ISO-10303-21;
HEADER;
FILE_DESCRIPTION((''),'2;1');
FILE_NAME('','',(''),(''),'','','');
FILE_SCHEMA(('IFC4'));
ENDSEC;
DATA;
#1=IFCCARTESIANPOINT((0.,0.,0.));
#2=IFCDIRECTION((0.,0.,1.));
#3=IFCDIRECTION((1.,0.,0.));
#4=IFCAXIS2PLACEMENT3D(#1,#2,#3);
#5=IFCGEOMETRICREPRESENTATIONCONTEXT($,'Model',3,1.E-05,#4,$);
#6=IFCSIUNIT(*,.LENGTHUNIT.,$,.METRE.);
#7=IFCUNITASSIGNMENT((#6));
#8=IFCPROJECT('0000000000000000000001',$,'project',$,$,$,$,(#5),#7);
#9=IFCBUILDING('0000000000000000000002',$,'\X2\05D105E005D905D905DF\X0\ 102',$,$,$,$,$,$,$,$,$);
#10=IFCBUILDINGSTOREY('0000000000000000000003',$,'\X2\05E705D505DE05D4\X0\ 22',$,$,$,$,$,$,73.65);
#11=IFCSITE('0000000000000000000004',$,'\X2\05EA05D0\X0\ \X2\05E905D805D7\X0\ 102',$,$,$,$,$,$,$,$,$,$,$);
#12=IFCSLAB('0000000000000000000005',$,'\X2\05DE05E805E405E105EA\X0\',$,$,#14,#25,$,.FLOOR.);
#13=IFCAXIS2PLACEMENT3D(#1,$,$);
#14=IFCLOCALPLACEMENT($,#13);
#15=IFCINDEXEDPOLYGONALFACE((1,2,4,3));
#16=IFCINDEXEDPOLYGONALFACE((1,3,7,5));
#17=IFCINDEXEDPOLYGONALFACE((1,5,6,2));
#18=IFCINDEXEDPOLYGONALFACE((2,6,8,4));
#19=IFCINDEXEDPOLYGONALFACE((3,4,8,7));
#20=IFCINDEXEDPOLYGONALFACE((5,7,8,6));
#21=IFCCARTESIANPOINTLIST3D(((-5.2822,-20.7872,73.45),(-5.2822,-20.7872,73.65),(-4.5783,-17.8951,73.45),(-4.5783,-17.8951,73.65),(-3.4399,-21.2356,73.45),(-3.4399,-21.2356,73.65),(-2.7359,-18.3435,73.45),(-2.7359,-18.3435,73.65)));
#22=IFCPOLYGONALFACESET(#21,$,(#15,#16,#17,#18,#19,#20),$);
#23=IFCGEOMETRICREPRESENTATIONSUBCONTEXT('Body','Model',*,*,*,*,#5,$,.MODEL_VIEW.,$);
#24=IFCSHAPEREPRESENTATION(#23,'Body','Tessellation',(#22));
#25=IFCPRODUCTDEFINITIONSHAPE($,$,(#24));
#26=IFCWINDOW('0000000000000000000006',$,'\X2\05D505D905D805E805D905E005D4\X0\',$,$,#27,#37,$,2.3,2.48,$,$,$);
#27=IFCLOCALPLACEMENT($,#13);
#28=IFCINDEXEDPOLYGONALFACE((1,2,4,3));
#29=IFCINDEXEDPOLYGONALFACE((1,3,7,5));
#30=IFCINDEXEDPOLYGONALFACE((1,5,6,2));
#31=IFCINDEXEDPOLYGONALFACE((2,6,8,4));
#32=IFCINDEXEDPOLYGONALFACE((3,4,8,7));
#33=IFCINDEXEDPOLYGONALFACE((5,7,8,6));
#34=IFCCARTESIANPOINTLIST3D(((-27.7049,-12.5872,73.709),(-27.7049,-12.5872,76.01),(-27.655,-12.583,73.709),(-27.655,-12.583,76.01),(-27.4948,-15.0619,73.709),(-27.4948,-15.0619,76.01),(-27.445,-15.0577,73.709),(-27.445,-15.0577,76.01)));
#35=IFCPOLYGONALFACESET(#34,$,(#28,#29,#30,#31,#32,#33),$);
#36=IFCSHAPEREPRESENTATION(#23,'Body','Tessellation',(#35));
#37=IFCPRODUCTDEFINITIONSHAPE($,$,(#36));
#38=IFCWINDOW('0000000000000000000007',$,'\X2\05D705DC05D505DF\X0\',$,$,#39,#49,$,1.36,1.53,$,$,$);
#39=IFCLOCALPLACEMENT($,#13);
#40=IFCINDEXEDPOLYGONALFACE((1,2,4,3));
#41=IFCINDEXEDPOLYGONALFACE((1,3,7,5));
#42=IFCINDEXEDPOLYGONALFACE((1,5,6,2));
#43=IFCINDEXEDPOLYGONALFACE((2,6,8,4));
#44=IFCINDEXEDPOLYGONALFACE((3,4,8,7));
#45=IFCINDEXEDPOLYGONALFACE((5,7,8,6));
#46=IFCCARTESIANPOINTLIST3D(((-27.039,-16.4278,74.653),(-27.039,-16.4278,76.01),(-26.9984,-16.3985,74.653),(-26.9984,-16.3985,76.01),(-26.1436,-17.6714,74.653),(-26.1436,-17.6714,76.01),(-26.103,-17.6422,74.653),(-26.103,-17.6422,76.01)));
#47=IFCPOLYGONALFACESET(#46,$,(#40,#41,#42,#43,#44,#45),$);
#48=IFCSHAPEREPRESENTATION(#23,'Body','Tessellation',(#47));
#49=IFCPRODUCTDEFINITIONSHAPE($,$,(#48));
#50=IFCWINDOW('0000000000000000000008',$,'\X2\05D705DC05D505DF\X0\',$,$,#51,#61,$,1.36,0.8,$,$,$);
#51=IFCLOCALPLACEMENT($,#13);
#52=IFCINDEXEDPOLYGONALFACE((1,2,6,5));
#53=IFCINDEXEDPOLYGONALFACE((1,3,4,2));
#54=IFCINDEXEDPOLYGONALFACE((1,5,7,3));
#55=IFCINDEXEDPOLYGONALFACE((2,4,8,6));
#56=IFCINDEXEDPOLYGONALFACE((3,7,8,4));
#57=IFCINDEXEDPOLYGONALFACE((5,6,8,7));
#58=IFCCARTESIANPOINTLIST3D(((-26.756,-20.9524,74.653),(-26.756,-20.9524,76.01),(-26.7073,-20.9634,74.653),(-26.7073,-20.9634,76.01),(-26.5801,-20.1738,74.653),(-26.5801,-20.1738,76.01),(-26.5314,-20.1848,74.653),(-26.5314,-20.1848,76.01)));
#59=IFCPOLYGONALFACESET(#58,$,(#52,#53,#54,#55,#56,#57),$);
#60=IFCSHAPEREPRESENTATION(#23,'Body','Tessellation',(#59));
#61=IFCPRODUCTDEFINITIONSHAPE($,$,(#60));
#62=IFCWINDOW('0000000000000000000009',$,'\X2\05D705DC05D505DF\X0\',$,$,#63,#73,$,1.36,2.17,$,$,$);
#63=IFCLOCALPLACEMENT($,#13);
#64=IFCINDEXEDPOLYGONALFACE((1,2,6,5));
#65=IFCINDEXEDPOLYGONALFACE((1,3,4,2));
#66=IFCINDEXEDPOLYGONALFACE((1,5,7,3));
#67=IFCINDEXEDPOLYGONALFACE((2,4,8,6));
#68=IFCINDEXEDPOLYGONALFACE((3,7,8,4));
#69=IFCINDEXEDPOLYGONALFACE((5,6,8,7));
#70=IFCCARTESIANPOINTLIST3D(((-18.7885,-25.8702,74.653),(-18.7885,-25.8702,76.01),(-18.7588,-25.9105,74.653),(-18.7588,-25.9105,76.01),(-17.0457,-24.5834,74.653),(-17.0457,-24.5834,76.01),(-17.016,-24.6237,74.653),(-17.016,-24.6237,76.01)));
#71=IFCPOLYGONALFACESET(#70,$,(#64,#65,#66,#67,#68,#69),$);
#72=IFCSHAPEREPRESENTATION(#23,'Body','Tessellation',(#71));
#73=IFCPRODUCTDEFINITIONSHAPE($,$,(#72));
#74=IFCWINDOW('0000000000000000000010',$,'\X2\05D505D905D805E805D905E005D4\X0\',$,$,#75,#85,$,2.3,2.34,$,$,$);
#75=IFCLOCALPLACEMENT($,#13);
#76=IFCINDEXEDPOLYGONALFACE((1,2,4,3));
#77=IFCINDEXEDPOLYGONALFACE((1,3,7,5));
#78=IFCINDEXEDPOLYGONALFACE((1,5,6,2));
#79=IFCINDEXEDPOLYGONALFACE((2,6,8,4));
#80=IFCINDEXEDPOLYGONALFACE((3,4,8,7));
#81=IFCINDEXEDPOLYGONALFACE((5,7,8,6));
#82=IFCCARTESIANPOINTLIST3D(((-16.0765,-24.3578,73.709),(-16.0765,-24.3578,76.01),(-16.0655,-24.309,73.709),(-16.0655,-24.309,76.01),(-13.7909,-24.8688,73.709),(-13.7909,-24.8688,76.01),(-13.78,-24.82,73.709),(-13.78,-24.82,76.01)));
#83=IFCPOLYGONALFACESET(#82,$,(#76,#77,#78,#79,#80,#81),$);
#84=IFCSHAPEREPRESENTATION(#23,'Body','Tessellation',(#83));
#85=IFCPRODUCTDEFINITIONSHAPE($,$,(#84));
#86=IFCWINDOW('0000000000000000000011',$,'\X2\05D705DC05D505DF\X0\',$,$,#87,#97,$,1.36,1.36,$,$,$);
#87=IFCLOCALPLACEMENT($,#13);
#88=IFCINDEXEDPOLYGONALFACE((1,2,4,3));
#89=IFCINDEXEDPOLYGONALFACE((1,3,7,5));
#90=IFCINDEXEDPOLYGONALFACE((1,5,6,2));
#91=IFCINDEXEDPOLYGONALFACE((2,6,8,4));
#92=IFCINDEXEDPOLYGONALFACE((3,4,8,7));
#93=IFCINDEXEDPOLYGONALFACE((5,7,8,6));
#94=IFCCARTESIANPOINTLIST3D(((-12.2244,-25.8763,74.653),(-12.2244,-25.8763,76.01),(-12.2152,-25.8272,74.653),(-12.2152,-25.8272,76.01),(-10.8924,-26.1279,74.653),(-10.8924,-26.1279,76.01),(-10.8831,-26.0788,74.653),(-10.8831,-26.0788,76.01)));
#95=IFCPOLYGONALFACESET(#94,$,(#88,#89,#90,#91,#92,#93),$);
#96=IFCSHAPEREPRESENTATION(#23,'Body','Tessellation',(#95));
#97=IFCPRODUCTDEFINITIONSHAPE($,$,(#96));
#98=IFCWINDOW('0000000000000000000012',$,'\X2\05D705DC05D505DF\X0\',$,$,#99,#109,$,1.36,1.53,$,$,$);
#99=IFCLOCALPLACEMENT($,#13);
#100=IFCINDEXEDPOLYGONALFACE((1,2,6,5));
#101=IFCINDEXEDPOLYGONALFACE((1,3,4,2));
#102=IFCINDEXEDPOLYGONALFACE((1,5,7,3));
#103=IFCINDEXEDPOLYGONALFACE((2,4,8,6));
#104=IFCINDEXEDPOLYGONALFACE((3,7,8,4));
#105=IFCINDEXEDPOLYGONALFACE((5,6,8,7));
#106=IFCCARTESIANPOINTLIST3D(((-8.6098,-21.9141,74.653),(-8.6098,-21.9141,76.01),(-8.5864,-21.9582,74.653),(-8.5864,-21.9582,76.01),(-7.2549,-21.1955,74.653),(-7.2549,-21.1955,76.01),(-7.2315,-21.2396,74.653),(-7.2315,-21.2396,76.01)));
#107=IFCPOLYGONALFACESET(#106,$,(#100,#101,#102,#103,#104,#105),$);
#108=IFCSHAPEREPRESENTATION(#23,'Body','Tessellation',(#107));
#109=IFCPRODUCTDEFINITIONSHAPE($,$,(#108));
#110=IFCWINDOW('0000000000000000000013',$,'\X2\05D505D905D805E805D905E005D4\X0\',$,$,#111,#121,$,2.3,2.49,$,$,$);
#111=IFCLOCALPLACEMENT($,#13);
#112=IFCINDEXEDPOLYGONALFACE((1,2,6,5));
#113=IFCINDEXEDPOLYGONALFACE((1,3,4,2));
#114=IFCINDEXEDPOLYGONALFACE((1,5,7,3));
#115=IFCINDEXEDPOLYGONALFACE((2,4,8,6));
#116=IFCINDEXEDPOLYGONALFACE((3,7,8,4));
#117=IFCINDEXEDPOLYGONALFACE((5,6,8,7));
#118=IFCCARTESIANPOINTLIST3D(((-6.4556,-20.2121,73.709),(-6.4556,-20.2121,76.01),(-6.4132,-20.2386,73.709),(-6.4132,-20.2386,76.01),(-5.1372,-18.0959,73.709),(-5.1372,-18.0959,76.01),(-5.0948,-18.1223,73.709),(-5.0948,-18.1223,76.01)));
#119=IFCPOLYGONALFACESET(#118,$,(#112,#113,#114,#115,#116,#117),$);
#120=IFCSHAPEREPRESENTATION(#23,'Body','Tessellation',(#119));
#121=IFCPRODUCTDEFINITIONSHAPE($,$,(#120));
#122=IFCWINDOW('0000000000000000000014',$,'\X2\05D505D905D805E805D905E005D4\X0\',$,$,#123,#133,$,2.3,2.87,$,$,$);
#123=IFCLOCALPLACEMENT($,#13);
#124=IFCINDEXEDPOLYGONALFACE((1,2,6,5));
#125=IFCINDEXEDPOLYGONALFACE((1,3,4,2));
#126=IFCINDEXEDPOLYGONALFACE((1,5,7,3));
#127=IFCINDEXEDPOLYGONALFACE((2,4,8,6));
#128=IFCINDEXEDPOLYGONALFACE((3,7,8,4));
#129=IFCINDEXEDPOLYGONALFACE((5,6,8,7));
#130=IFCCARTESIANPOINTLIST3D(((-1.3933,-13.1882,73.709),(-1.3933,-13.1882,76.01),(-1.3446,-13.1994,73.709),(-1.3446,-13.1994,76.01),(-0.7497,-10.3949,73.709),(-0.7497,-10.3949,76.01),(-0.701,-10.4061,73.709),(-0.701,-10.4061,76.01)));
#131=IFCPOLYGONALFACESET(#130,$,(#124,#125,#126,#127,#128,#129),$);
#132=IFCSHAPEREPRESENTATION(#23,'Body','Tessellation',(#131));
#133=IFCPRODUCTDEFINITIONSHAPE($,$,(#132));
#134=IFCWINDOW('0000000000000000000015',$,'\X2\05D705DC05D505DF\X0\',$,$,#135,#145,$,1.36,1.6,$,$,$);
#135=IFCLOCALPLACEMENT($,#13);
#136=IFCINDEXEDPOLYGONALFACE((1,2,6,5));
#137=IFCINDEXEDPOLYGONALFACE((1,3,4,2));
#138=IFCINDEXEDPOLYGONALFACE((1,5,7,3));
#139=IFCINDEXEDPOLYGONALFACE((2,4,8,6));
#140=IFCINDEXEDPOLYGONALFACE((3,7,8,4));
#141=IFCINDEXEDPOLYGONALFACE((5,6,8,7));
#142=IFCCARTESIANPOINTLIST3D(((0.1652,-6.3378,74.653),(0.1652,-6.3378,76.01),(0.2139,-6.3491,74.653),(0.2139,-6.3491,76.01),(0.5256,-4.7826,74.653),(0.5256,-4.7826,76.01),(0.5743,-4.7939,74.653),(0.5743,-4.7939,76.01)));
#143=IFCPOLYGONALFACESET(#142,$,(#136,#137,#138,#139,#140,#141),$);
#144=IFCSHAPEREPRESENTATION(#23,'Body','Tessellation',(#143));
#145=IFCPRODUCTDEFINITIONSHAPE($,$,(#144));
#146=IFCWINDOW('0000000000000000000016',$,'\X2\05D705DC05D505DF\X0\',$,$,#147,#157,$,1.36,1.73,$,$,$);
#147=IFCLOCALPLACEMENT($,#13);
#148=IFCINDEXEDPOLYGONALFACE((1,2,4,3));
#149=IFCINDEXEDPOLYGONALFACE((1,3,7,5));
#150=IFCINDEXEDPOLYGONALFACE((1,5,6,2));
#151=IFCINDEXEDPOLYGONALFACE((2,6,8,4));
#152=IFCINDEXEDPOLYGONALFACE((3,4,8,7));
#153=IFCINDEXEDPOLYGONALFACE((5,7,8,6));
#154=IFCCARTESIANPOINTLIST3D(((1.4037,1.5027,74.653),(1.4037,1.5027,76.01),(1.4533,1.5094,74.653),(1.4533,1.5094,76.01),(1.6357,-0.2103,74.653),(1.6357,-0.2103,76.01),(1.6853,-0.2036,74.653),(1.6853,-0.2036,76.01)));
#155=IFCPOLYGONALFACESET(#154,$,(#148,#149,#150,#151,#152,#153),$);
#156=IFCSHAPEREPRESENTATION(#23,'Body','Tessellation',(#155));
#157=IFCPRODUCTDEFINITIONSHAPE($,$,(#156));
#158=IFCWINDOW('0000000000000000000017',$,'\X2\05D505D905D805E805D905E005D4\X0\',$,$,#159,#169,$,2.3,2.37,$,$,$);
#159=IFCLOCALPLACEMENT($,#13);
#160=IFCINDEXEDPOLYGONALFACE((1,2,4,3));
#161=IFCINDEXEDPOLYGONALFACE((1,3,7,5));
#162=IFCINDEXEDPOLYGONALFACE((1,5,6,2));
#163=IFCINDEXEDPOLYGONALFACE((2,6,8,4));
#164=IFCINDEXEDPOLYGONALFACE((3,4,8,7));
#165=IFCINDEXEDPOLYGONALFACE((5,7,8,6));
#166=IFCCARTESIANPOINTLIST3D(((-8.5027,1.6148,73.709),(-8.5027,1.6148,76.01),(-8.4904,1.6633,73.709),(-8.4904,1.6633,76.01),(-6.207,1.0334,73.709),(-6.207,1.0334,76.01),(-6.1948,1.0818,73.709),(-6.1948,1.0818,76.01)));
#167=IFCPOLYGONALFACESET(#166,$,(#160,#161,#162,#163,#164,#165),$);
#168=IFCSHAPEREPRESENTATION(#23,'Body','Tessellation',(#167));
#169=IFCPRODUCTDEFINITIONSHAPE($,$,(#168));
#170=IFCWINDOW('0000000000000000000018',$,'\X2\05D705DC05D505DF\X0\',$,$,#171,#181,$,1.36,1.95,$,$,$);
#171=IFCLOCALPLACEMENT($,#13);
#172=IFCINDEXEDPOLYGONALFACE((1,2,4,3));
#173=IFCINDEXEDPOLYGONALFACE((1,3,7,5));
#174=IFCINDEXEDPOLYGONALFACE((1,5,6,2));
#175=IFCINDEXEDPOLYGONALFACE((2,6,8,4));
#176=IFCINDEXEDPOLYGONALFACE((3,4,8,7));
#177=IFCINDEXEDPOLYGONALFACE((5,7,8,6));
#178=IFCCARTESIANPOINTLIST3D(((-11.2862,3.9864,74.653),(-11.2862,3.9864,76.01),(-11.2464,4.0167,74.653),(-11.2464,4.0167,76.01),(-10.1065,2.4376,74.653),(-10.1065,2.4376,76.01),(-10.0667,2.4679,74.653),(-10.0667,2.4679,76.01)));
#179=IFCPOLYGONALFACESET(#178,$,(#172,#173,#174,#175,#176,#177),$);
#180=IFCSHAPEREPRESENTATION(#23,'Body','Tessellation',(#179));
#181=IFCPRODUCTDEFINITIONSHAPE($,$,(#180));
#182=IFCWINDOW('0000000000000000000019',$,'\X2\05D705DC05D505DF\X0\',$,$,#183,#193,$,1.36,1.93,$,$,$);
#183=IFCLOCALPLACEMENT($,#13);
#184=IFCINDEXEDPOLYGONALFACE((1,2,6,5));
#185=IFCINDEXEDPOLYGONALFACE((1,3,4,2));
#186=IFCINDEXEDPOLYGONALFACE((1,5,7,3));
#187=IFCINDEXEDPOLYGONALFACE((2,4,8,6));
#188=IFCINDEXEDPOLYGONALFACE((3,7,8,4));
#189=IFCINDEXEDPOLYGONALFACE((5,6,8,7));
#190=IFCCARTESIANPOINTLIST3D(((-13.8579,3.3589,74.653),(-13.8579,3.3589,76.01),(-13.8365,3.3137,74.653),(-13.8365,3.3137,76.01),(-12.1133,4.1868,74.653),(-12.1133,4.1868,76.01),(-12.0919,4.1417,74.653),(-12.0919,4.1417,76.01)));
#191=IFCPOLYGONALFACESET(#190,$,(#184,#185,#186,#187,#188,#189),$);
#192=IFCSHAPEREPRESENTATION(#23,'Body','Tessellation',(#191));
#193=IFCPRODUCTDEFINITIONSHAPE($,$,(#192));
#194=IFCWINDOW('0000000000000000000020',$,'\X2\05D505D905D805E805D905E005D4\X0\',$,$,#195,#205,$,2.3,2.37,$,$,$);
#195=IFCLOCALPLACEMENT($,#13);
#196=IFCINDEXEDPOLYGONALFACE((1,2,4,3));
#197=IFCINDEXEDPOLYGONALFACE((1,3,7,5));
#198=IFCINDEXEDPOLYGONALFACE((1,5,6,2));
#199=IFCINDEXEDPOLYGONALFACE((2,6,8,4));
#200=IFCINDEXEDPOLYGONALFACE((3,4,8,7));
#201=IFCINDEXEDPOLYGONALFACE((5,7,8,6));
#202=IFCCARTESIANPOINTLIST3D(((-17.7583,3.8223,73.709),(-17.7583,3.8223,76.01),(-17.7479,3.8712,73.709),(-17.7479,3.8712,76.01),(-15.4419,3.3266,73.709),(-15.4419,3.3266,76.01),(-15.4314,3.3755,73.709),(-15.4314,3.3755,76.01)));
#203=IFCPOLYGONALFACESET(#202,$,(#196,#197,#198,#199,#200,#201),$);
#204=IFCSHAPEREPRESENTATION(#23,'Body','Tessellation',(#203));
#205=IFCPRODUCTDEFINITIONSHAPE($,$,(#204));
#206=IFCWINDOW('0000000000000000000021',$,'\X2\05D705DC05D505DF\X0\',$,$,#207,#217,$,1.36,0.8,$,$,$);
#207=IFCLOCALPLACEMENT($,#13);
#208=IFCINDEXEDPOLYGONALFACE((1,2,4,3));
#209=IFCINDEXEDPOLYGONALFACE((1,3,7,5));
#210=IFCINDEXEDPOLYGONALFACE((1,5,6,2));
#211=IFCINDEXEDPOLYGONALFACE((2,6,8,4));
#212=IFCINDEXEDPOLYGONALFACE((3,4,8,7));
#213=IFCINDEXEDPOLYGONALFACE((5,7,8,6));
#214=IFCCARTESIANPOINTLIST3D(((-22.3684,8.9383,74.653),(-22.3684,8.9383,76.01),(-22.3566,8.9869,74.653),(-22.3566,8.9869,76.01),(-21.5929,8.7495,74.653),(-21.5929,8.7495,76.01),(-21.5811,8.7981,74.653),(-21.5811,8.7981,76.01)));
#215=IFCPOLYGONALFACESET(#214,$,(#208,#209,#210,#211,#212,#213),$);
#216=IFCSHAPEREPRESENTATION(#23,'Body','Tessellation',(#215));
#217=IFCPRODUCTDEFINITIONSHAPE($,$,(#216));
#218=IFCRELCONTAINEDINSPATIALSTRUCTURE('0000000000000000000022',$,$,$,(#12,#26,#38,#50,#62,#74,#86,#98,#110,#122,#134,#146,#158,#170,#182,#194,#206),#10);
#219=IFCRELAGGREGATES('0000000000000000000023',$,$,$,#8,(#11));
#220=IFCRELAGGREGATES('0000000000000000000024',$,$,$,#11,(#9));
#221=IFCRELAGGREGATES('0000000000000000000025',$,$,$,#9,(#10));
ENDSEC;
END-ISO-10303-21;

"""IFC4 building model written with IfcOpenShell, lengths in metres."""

from ifc_helpers import new_model, si_unit, frame, origin_with_axes, context, subcontext, project, spatial, polyline, outline, extrude, element, save


model = new_model("IFC4")

# Units and contexts
model_context = context("Model", 3, precision=1e-05, world=origin_with_axes())
body_context = subcontext(model_context, "Body", "Model", "MODEL_VIEW")
ifc_project = project(units=[si_unit("LENGTHUNIT", "METRE")], contexts=[model_context])

# Site, building, storey
site = spatial("IfcSite", under=ifc_project, Name="תא שטח 102")
building = spatial("IfcBuilding", under=site, Name="בניין 102")
storey = spatial("IfcBuildingStorey", under=building, Name="קומה 22", Elevation=73.65)

# Slab
element("IfcSlab", 1, inside=storey, Name="מרפסת", PredefinedType="FLOOR", context=body_context, shape_type="SweptSolid", body=[
    extrude(outline(polyline([(-4.5783, -17.8951), (-2.7359, -18.3435), (-3.4399, -21.2356), (-5.2822, -20.7872), (-4.5783, -17.8951)])), frame((0.0, 0.0, 73.45)), (0.0, 0.0, 1.0), 0.2),
])

# Windows
element("IfcWindow", 2, inside=storey, Name="ויטרינה", OverallHeight=2.3, OverallWidth=2.48, context=body_context, shape_type="SweptSolid", body=[
    extrude(outline(polyline([(-27.7049, -12.5872), (-27.4948, -15.0619), (-27.445, -15.0577), (-27.655, -12.583), (-27.7049, -12.5872)])), frame((0.0, 0.0, 73.709)), (0.0, 0.0, 1.0), 2.301),
])
element("IfcWindow", 3, inside=storey, Name="חלון", OverallHeight=1.36, OverallWidth=1.53, context=body_context, shape_type="SweptSolid", body=[
    extrude(outline(polyline([(-27.039, -16.4278), (-26.1436, -17.6714), (-26.103, -17.6422), (-26.9984, -16.3985), (-27.039, -16.4278)])), frame((0.0, 0.0, 74.653)), (0.0, 0.0, 1.0), 1.357),
])
element("IfcWindow", 4, inside=storey, Name="חלון", OverallHeight=1.36, OverallWidth=0.8, context=body_context, shape_type="SweptSolid", body=[
    extrude(outline(polyline([(-26.5801, -20.1738), (-26.756, -20.9524), (-26.7073, -20.9634), (-26.5314, -20.1848), (-26.5801, -20.1738)])), frame((0.0, 0.0, 74.653)), (0.0, 0.0, 1.0), 1.357),
])
element("IfcWindow", 5, inside=storey, Name="חלון", OverallHeight=1.36, OverallWidth=2.17, context=body_context, shape_type="SweptSolid", body=[
    extrude(outline(polyline([(-18.7588, -25.9105), (-17.016, -24.6237), (-17.0457, -24.5834), (-18.7885, -25.8702), (-18.7588, -25.9105)])), frame((0.0, 0.0, 74.653)), (0.0, 0.0, 1.0), 1.357),
])
element("IfcWindow", 6, inside=storey, Name="ויטרינה", OverallHeight=2.3, OverallWidth=2.34, context=body_context, shape_type="SweptSolid", body=[
    extrude(outline(polyline([(-16.0765, -24.3578), (-13.7909, -24.8688), (-13.78, -24.82), (-16.0655, -24.309), (-16.0765, -24.3578)])), frame((0.0, 0.0, 73.709)), (0.0, 0.0, 1.0), 2.301),
])
element("IfcWindow", 7, inside=storey, Name="חלון", OverallHeight=1.36, OverallWidth=1.36, context=body_context, shape_type="SweptSolid", body=[
    extrude(outline(polyline([(-12.2244, -25.8763), (-10.8924, -26.1279), (-10.8831, -26.0788), (-12.2152, -25.8272), (-12.2244, -25.8763)])), frame((0.0, 0.0, 74.653)), (0.0, 0.0, 1.0), 1.357),
])
element("IfcWindow", 8, inside=storey, Name="חלון", OverallHeight=1.36, OverallWidth=1.53, context=body_context, shape_type="SweptSolid", body=[
    extrude(outline(polyline([(-8.5864, -21.9582), (-7.2315, -21.2396), (-7.2549, -21.1955), (-8.6098, -21.9141), (-8.5864, -21.9582)])), frame((0.0, 0.0, 74.653)), (0.0, 0.0, 1.0), 1.357),
])
element("IfcWindow", 9, inside=storey, Name="ויטרינה", OverallHeight=2.3, OverallWidth=2.49, context=body_context, shape_type="SweptSolid", body=[
    extrude(outline(polyline([(-6.4132, -20.2386), (-5.0948, -18.1223), (-5.1372, -18.0959), (-6.4556, -20.2121), (-6.4132, -20.2386)])), frame((0.0, 0.0, 73.709)), (0.0, 0.0, 1.0), 2.301),
])
element("IfcWindow", 10, inside=storey, Name="ויטרינה", OverallHeight=2.3, OverallWidth=2.87, context=body_context, shape_type="SweptSolid", body=[
    extrude(outline(polyline([(-1.3446, -13.1994), (-0.701, -10.4061), (-0.7497, -10.3949), (-1.3933, -13.1882), (-1.3446, -13.1994)])), frame((0.0, 0.0, 73.709)), (0.0, 0.0, 1.0), 2.301),
])
element("IfcWindow", 11, inside=storey, Name="חלון", OverallHeight=1.36, OverallWidth=1.6, context=body_context, shape_type="SweptSolid", body=[
    extrude(outline(polyline([(0.2139, -6.3491), (0.5743, -4.7939), (0.5256, -4.7826), (0.1652, -6.3378), (0.2139, -6.3491)])), frame((0.0, 0.0, 74.653)), (0.0, 0.0, 1.0), 1.357),
])
element("IfcWindow", 12, inside=storey, Name="חלון", OverallHeight=1.36, OverallWidth=1.73, context=body_context, shape_type="SweptSolid", body=[
    extrude(outline(polyline([(1.6853, -0.2036), (1.4533, 1.5094), (1.4037, 1.5027), (1.6357, -0.2103), (1.6853, -0.2036)])), frame((0.0, 0.0, 74.653)), (0.0, 0.0, 1.0), 1.357),
])
element("IfcWindow", 13, inside=storey, Name="ויטרינה", OverallHeight=2.3, OverallWidth=2.37, context=body_context, shape_type="SweptSolid", body=[
    extrude(outline(polyline([(-6.1948, 1.0818), (-8.4904, 1.6633), (-8.5027, 1.6148), (-6.207, 1.0334), (-6.1948, 1.0818)])), frame((0.0, 0.0, 73.709)), (0.0, 0.0, 1.0), 2.301),
])
element("IfcWindow", 14, inside=storey, Name="חלון", OverallHeight=1.36, OverallWidth=1.95, context=body_context, shape_type="SweptSolid", body=[
    extrude(outline(polyline([(-10.0667, 2.4679), (-11.2464, 4.0167), (-11.2862, 3.9864), (-10.1065, 2.4376), (-10.0667, 2.4679)])), frame((0.0, 0.0, 74.653)), (0.0, 0.0, 1.0), 1.357),
])
element("IfcWindow", 15, inside=storey, Name="חלון", OverallHeight=1.36, OverallWidth=1.93, context=body_context, shape_type="SweptSolid", body=[
    extrude(outline(polyline([(-12.1133, 4.1868), (-13.8579, 3.3589), (-13.8365, 3.3137), (-12.0919, 4.1417), (-12.1133, 4.1868)])), frame((0.0, 0.0, 74.653)), (0.0, 0.0, 1.0), 1.357),
])
element("IfcWindow", 16, inside=storey, Name="ויטרינה", OverallHeight=2.3, OverallWidth=2.37, context=body_context, shape_type="SweptSolid", body=[
    extrude(outline(polyline([(-15.4314, 3.3755), (-17.7479, 3.8712), (-17.7583, 3.8223), (-15.4419, 3.3266), (-15.4314, 3.3755)])), frame((0.0, 0.0, 73.709)), (0.0, 0.0, 1.0), 2.301),
])
element("IfcWindow", 17, inside=storey, Name="חלון", OverallHeight=1.36, OverallWidth=0.8, context=body_context, shape_type="SweptSolid", body=[
    extrude(outline(polyline([(-21.5811, 8.7981), (-22.3566, 8.9869), (-22.3684, 8.9383), (-21.5929, 8.7495), (-21.5811, 8.7981)])), frame((0.0, 0.0, 74.653)), (0.0, 0.0, 1.0), 1.357),
])

save(model, "model.ifc")
